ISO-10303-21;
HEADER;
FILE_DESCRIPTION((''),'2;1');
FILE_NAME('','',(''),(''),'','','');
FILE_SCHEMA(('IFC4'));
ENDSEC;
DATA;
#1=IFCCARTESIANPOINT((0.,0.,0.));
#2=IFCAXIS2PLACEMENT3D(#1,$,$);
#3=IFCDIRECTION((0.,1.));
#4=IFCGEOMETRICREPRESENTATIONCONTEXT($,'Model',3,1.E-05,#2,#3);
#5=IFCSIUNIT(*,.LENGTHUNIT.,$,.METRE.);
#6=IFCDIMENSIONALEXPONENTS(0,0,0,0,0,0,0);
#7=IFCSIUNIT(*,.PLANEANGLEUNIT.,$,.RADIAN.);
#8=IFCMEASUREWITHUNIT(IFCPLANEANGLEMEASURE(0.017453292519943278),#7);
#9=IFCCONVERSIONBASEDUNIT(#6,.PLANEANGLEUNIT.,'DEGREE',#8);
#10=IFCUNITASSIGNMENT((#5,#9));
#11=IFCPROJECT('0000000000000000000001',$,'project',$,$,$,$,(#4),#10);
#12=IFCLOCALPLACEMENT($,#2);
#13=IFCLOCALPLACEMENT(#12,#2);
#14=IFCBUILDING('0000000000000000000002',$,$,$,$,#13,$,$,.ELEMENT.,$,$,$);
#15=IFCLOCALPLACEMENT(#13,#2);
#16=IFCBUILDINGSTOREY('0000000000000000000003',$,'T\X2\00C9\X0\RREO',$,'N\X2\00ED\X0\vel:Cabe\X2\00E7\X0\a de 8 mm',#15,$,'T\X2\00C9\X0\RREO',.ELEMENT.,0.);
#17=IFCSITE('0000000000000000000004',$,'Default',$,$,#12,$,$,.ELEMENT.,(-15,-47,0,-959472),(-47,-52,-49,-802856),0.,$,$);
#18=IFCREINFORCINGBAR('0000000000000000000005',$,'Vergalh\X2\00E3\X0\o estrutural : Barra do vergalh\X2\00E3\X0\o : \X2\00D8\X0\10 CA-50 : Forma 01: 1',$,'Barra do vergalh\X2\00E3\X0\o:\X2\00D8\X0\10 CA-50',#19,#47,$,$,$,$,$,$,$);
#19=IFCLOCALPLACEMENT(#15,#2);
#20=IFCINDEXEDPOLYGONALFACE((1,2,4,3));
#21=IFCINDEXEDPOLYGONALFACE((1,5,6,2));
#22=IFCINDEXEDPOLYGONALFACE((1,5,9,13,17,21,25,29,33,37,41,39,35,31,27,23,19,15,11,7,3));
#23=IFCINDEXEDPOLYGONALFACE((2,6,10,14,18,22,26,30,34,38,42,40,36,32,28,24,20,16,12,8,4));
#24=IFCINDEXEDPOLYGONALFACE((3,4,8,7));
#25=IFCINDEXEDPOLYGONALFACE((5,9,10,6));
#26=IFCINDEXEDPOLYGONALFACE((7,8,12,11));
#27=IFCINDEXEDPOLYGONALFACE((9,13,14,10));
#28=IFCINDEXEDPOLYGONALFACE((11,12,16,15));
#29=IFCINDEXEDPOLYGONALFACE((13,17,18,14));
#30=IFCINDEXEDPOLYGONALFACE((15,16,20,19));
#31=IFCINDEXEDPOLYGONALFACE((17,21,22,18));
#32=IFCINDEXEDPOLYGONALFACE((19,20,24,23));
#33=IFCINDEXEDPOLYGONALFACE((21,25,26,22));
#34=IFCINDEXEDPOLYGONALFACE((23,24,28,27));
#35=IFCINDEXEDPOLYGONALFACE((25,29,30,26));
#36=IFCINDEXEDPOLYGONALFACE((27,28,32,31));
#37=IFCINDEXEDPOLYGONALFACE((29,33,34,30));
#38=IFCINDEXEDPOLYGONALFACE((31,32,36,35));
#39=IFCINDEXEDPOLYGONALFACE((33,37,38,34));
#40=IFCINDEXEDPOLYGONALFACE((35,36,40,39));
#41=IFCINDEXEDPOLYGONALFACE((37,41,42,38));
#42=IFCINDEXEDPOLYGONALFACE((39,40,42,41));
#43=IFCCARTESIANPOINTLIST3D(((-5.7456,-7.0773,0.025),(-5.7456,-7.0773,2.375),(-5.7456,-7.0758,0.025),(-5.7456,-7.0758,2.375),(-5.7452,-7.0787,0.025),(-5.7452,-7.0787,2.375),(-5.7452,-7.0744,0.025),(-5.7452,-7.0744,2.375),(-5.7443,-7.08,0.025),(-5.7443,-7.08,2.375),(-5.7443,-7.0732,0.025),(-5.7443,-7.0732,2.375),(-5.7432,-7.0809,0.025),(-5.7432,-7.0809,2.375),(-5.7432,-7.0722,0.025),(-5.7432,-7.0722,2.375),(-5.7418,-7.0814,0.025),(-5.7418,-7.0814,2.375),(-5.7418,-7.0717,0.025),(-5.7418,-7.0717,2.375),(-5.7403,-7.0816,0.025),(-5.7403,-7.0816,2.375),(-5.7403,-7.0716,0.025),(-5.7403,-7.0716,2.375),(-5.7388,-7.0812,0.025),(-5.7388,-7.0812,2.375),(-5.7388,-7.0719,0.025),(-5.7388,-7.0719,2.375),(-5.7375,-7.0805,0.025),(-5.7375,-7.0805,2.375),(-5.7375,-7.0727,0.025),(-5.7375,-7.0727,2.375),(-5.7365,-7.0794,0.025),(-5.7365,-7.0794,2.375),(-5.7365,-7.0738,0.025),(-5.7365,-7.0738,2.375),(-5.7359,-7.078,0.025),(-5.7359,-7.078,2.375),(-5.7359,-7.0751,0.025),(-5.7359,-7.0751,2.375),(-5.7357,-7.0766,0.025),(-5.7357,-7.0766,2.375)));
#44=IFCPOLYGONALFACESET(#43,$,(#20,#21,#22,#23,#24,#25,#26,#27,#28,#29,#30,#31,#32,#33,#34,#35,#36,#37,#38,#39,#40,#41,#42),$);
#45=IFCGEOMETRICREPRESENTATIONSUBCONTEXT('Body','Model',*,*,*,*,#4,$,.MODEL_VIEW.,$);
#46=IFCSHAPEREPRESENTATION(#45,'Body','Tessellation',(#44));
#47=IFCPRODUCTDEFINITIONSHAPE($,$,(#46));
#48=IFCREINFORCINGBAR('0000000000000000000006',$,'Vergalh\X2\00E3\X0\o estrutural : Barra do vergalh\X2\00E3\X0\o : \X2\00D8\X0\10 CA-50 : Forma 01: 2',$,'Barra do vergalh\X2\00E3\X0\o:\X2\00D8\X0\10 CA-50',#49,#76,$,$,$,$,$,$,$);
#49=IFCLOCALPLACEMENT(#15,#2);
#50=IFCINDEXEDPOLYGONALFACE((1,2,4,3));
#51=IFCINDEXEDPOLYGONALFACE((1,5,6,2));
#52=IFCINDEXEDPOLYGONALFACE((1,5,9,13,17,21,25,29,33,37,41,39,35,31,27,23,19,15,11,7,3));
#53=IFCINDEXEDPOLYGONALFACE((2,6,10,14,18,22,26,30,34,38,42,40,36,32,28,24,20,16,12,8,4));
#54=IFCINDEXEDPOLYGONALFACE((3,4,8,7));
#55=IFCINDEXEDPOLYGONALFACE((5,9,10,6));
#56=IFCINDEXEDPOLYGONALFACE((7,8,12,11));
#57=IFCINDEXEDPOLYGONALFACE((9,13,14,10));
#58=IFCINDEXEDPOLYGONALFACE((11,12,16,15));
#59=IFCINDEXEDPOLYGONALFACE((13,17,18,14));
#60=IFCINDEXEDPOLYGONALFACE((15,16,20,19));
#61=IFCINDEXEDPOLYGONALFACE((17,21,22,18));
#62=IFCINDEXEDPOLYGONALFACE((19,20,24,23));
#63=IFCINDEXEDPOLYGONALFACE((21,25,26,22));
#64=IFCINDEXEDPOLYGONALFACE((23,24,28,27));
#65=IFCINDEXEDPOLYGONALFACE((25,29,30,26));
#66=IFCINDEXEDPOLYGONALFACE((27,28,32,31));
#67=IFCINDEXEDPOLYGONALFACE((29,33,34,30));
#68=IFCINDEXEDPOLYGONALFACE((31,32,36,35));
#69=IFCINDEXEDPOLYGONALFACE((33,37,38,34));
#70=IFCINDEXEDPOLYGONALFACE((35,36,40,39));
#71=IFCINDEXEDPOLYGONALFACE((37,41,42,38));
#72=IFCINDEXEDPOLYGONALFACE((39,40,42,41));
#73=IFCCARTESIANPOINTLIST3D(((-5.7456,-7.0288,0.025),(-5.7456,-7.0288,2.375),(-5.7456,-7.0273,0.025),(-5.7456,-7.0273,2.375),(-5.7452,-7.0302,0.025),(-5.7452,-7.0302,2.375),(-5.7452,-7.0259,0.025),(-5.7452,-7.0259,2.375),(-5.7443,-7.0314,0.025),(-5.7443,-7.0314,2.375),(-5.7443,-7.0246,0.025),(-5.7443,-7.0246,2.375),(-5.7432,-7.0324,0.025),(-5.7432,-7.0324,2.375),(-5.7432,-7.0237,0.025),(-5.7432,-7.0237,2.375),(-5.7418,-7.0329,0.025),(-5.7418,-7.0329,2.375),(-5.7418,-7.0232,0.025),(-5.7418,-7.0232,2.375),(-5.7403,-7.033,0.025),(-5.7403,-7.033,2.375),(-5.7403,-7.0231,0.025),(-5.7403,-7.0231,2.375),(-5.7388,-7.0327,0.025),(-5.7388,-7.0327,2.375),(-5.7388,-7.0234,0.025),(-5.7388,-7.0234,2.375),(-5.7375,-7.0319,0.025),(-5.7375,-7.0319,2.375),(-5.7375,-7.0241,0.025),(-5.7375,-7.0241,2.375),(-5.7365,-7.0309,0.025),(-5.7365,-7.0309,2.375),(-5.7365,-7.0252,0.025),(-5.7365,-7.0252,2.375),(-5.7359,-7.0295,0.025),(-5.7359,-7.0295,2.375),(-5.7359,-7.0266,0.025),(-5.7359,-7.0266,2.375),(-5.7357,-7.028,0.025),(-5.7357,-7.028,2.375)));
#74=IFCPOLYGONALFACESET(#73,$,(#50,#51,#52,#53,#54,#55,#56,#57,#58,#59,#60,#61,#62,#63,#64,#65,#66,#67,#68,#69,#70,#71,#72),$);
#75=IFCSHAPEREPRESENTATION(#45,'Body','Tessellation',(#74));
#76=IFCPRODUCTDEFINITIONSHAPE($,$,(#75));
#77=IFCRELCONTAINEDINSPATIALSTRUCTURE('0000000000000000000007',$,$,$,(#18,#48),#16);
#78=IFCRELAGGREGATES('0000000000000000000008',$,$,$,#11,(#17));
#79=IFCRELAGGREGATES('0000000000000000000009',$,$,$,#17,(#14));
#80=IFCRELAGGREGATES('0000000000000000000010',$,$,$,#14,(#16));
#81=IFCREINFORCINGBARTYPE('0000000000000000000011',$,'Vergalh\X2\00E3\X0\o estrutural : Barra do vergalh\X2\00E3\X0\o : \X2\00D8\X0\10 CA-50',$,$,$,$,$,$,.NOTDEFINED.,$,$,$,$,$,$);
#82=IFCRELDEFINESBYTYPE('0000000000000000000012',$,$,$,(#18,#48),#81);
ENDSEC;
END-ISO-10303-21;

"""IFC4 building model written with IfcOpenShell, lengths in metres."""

from ifc_helpers import new_model, entity, si_unit, converted_unit, direction, origin, place, context, subcontext, project, spatial, type_object, element, save


model = new_model("IFC4")

# Units and contexts
model_context = context("Model", 3, precision=1e-05, world=origin(), true_north=direction((0.0, 1.0)))
body_context = subcontext(model_context, "Body", "Model", "MODEL_VIEW")
ifc_project = project(units=[si_unit("LENGTHUNIT", "METRE"), converted_unit("PLANEANGLEUNIT", "DEGREE", entity("IfcPlaneAngleMeasure", 0.017453292519943278), si_unit("PLANEANGLEUNIT", "RADIAN"), dimensions=[0, 0, 0, 0, 0, 0, 0])], contexts=[model_context])

# Site, building, storey
site_placement = place(None, origin())
site = spatial("IfcSite", under=ifc_project, at=site_placement, Name="Default", CompositionType="ELEMENT", RefLatitude=(-15, -47, 0, -959472), RefLongitude=(-47, -52, -49, -802856), RefElevation=0.0)
building_placement = place(site_placement, origin())
building = spatial("IfcBuilding", under=site, at=building_placement, CompositionType="ELEMENT")
storey_placement = place(building_placement, origin())
storey = spatial("IfcBuildingStorey", under=building, at=storey_placement, Name="TÉRREO", ObjectType="Nível:Cabeça de 8 mm", LongName="TÉRREO", CompositionType="ELEMENT", Elevation=0.0)

# Reinforcing bars
reinforcing_bar_type_1 = type_object("IfcReinforcingBarType", Name="Vergalhão estrutural : Barra do vergalhão : Ø10 CA-50", PredefinedType="NOTDEFINED")
reinforcing_bar_1_placement = place(storey_placement, origin())
element("IfcReinforcingBar", 1, at=reinforcing_bar_1_placement, inside=storey, type_object=reinforcing_bar_type_1, Name="Vergalhão estrutural : Barra do vergalhão : Ø10 CA-50 : Forma 01: 1", ObjectType="Barra do vergalhão:Ø10 CA-50", context=body_context, shape_type="AdvancedSweptSolid", body=[
    entity("IfcSweptDiskSolid", entity("IfcIndexedPolyCurve", entity("IfcCartesianPointList3D", [[-5.7407, -7.0766, 0.025], [-5.7407, -7.0766, 2.375]]), None, False), 0.005, None, 0.0, 1.0),
])
reinforcing_bar_2_placement = place(storey_placement, origin())
element("IfcReinforcingBar", 2, at=reinforcing_bar_2_placement, inside=storey, type_object=reinforcing_bar_type_1, Name="Vergalhão estrutural : Barra do vergalhão : Ø10 CA-50 : Forma 01: 2", ObjectType="Barra do vergalhão:Ø10 CA-50", context=body_context, shape_type="AdvancedSweptSolid", body=[
    entity("IfcSweptDiskSolid", entity("IfcIndexedPolyCurve", entity("IfcCartesianPointList3D", [[-5.7407, -7.028, 0.025], [-5.7407, -7.028, 2.375]]), None, False), 0.005, None, 0.0, 1.0),
])

save(model, "model.ifc")
